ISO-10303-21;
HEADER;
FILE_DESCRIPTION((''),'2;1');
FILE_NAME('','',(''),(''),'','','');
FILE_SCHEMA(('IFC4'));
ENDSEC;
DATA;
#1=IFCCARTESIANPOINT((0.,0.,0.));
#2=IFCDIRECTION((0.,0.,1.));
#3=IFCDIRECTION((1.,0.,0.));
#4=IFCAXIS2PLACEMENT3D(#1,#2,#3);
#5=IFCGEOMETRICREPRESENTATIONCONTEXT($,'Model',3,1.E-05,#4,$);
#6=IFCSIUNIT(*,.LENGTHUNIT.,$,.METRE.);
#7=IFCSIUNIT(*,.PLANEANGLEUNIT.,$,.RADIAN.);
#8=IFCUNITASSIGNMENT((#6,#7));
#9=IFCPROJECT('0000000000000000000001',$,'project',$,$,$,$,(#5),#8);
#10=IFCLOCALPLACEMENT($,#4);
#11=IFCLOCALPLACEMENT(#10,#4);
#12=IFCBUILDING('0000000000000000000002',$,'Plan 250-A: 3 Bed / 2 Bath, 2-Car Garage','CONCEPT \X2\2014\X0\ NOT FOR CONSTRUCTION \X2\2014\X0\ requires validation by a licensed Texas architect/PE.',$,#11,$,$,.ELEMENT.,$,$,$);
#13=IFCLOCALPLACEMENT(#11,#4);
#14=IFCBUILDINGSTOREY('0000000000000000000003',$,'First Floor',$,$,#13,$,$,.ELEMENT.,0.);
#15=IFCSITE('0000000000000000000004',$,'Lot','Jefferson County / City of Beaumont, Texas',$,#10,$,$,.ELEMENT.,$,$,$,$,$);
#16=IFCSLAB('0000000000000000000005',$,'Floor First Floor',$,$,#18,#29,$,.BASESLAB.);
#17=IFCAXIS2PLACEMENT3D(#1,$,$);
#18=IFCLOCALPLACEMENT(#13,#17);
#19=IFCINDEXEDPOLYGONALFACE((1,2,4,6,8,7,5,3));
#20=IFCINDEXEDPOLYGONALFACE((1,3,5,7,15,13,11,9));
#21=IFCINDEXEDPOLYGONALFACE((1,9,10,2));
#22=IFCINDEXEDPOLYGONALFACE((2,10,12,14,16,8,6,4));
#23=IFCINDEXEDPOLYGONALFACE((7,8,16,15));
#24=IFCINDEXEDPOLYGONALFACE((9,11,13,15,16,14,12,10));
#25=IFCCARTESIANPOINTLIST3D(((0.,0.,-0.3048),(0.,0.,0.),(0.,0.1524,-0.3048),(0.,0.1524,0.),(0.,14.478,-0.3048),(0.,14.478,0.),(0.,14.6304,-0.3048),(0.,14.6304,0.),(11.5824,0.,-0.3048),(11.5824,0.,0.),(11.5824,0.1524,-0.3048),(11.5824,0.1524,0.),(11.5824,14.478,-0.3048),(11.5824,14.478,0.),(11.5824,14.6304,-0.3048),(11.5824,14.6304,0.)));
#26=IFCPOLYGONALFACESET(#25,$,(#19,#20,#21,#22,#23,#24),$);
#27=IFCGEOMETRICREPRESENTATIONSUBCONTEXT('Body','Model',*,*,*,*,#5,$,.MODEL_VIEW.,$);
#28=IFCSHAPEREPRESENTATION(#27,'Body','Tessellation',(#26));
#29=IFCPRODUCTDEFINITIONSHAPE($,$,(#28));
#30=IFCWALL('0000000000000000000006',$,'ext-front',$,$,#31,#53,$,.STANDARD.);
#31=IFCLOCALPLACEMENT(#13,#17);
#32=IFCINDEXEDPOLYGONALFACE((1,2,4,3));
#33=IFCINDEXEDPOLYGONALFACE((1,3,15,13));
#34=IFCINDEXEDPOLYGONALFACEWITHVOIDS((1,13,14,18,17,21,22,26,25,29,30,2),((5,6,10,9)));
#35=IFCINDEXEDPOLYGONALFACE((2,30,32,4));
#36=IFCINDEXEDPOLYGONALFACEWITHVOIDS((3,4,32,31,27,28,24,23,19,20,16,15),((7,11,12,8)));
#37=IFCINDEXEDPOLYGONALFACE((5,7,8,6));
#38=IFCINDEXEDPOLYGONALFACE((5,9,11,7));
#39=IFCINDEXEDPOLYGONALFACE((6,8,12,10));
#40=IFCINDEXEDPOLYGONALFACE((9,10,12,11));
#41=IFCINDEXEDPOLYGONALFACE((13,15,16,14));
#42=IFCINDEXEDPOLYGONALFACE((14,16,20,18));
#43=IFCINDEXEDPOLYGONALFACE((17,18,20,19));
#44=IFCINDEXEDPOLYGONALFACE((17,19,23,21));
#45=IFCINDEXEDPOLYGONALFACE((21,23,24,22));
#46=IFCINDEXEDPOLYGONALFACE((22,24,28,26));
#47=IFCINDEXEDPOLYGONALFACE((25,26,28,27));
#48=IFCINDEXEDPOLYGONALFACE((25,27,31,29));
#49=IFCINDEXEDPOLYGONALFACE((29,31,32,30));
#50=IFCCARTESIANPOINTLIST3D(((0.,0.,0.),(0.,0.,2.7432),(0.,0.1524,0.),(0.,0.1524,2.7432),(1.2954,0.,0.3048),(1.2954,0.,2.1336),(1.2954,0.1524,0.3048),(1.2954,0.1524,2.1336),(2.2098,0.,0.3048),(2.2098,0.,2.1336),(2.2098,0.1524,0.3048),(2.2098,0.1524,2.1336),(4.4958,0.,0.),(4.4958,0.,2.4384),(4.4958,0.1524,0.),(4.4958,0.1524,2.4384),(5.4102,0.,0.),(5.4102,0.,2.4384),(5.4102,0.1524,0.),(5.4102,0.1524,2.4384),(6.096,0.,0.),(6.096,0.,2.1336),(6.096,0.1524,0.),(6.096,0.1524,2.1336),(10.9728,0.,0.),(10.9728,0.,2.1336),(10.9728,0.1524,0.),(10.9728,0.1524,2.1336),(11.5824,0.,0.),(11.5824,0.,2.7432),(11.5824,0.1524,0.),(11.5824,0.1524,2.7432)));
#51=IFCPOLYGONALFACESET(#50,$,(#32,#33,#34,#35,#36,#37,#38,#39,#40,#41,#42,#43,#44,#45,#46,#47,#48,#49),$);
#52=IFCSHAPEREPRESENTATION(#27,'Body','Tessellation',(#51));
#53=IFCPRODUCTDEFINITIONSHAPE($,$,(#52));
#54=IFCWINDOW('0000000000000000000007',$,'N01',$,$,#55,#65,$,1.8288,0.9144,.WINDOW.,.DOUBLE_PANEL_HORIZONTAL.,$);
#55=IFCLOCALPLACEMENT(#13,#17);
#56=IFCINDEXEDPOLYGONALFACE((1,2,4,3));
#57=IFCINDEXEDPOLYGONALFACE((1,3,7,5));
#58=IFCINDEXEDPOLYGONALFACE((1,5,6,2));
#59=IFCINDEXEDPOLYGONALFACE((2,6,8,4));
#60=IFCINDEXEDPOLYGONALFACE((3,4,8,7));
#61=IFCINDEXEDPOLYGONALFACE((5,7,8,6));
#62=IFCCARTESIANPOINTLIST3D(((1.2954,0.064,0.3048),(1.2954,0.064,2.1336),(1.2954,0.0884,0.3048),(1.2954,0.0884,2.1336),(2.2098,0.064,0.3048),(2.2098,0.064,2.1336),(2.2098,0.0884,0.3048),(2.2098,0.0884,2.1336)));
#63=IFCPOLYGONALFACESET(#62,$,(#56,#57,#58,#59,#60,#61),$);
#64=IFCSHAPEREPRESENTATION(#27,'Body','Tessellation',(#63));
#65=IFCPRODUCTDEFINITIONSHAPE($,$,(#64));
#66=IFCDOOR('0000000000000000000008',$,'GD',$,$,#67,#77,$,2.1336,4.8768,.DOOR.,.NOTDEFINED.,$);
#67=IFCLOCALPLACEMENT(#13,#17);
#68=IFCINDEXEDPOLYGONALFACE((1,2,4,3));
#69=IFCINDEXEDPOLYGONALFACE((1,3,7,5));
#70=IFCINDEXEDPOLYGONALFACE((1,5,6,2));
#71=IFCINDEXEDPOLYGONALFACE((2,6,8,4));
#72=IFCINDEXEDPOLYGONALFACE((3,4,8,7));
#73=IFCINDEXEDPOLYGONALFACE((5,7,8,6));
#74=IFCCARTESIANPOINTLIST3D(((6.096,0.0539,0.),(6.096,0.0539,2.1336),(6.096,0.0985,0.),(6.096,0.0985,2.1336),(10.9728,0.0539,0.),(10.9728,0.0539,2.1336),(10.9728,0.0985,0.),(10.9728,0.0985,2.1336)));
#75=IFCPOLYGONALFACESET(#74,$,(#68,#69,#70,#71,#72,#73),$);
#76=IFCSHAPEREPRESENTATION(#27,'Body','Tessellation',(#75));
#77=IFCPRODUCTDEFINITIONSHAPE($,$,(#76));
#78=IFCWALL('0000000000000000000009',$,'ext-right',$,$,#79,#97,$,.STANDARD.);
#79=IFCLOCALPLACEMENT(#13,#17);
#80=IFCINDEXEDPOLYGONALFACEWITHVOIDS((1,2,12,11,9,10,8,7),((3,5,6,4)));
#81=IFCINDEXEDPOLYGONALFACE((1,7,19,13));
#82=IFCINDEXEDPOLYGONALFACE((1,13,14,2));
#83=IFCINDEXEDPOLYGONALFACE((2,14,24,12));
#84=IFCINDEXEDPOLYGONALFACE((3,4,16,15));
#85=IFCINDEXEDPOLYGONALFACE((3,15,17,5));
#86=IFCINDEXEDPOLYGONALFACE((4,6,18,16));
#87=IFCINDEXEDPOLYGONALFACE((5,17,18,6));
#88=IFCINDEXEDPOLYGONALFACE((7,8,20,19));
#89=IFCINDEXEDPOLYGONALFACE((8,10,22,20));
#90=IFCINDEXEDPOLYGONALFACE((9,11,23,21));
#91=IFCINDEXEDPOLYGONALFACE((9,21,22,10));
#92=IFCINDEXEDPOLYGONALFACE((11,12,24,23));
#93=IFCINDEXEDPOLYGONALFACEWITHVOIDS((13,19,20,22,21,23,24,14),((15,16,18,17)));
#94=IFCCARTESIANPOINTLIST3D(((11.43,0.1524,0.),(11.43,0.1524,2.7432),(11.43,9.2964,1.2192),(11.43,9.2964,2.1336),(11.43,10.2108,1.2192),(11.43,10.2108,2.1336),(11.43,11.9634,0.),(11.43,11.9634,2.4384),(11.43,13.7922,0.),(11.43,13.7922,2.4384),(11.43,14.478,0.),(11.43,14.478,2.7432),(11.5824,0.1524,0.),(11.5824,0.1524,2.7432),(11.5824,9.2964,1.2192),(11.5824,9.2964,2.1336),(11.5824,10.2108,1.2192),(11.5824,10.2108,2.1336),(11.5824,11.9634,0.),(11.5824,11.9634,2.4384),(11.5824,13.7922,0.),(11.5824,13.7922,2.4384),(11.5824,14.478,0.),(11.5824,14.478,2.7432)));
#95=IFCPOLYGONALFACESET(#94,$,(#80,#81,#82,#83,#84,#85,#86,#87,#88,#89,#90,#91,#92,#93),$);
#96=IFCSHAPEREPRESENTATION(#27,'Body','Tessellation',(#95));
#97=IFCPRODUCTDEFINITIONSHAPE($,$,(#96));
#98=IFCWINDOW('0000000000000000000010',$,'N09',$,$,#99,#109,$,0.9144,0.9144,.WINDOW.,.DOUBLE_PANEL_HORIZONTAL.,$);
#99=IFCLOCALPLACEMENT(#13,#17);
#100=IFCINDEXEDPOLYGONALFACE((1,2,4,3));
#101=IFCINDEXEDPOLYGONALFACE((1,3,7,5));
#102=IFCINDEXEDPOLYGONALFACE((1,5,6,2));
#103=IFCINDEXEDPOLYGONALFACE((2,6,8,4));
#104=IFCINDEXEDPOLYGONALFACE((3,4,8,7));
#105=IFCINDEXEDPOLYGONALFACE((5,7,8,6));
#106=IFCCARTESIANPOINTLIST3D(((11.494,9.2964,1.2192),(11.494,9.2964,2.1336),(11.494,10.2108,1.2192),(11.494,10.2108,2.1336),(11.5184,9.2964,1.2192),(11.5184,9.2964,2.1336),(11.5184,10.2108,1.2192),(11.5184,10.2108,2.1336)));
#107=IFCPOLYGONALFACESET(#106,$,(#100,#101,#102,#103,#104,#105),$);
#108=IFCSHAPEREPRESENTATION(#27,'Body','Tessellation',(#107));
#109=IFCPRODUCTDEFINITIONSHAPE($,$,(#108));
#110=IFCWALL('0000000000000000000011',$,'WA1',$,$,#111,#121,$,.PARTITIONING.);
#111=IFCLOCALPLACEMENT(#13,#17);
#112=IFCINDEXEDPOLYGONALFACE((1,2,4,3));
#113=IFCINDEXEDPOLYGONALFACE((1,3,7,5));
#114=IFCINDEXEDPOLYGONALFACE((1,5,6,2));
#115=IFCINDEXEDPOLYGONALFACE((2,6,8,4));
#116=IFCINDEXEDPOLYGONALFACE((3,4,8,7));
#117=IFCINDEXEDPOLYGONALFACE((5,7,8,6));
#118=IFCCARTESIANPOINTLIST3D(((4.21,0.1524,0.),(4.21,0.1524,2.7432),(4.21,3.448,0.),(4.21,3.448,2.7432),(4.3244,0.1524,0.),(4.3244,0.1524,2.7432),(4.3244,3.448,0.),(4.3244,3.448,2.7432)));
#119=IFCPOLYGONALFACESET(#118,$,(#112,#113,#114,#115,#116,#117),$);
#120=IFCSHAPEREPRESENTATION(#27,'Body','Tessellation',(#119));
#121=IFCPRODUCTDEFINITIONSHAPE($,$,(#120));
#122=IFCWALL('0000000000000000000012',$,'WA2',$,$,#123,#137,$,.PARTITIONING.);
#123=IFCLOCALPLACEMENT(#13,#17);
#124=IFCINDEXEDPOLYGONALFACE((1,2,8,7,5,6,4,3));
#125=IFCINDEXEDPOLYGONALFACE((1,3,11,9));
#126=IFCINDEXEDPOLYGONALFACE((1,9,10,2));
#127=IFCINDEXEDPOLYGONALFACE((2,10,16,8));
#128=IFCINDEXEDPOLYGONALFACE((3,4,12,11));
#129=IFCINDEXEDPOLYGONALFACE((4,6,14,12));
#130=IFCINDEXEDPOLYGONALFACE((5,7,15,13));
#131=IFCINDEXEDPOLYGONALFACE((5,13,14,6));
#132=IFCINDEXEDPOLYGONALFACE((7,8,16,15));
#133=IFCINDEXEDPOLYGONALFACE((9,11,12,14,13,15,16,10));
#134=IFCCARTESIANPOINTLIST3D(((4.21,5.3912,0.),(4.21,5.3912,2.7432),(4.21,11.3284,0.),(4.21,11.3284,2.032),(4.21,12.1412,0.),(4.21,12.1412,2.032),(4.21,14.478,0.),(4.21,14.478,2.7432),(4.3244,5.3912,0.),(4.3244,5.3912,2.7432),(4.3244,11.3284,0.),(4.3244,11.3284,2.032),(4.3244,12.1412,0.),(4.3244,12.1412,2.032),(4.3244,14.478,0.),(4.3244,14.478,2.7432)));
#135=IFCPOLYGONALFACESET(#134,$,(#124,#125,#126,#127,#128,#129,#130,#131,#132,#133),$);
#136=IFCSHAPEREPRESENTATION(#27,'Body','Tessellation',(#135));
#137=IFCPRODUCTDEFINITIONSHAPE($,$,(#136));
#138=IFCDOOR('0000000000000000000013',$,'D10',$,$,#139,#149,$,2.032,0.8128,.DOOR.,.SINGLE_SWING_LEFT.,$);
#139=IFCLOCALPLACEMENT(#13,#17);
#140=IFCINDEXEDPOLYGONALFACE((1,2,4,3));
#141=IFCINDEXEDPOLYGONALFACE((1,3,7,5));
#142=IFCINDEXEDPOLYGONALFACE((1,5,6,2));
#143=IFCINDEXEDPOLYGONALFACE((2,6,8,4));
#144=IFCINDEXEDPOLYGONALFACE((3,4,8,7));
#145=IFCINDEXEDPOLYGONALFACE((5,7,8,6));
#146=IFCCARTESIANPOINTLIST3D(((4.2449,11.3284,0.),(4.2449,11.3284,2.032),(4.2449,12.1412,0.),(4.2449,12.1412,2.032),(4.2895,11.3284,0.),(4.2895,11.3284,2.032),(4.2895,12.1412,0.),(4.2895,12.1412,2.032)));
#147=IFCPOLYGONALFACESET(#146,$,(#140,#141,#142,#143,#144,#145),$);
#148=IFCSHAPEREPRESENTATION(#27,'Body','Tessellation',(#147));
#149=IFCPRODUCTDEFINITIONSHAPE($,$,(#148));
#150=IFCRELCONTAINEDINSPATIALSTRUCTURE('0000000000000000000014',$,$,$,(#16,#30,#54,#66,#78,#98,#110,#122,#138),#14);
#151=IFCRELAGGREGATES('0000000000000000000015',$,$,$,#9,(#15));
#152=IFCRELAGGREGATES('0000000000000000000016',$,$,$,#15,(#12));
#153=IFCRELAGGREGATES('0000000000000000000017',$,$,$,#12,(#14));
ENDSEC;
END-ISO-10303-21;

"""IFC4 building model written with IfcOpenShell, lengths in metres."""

from ifc_helpers import new_model, si_unit, frame, frame_2d, origin_with_axes, place, context, subcontext, project, spatial, polyline, rectangle, outline, extrude, element, fill, save


model = new_model("IFC4")

# Units and contexts
model_context = context("Model", 3, precision=1e-05, world=origin_with_axes())
body_context = subcontext(model_context, "Body", "Model", "MODEL_VIEW")
ifc_project = project(units=[si_unit("LENGTHUNIT", "METRE"), si_unit("PLANEANGLEUNIT", "RADIAN")], contexts=[model_context])

# Site, building, storey
site_placement = place(None, origin_with_axes())
site = spatial("IfcSite", under=ifc_project, at=site_placement, Name="Lot", Description="Jefferson County / City of Beaumont, Texas", CompositionType="ELEMENT")
building_placement = place(site_placement, origin_with_axes())
building = spatial("IfcBuilding", under=site, at=building_placement, Name="Plan 250-A: 3 Bed / 2 Bath, 2-Car Garage", Description="CONCEPT — NOT FOR CONSTRUCTION — requires validation by a licensed Texas architect/PE.", CompositionType="ELEMENT")
storey_placement = place(building_placement, origin_with_axes())
storey = spatial("IfcBuildingStorey", under=building, at=storey_placement, Name="First Floor", CompositionType="ELEMENT", Elevation=0.0)

# Slab
slab_placement = place(storey_placement, frame((0.0, 0.0, -0.3048), z_axis=(0.0, 0.0, 1.0), x_axis=(1.0, 0.0, 0.0)))
element("IfcSlab", 1, at=slab_placement, inside=storey, Name="Floor First Floor", PredefinedType="BASESLAB", context=body_context, shape_type="SweptSolid", body=[
    extrude(outline(polyline([(11.5824, 0.1524), (11.5824, 0.0), (0.0, 0.0), (0.0, 0.1524), (0.0, 14.478), (0.0, 14.6304), (11.5824, 14.6304), (11.5824, 14.478), (11.5824, 0.1524)])), origin_with_axes(), (0.0, 0.0, 1.0), 0.3048),
])

# Wall, openings, window, door
wall_1_placement = place(storey_placement, frame((0.0, 0.0762, 0.0), z_axis=(0.0, 0.0, 1.0), x_axis=(1.0, 0.0, 0.0)))
wall_1 = element("IfcWall", 2, at=wall_1_placement, inside=storey, Name="ext-front", PredefinedType="STANDARD", context=body_context, shape_type="SweptSolid", body=[
    extrude(rectangle(XDim=11.5824, YDim=0.1524, at=frame_2d((5.7912, 0.0), x_axis=(1.0, 0.0))), origin_with_axes(), (0.0, 0.0, 1.0), 2.7432),
])
opening_1_placement = place(wall_1_placement, frame((1.2954, 0.0, 0.3048), z_axis=(0.0, 0.0, 1.0), x_axis=(1.0, 0.0, 0.0)))
opening_1 = element("IfcOpeningElement", 3, at=opening_1_placement, cuts=wall_1, PredefinedType="OPENING", context=body_context, shape_type="SweptSolid", body=[
    extrude(rectangle(XDim=0.9144, YDim=0.1829, at=frame_2d((0.4572, 0.0), x_axis=(1.0, 0.0))), origin_with_axes(), (0.0, 0.0, 1.0), 1.8288),
])
opening_2_placement = place(wall_1_placement, frame((4.4958, 0.0, 0.0), z_axis=(0.0, 0.0, 1.0), x_axis=(1.0, 0.0, 0.0)))
element("IfcOpeningElement", 4, at=opening_2_placement, cuts=wall_1, PredefinedType="OPENING", context=body_context, shape_type="SweptSolid", body=[
    extrude(rectangle(XDim=0.9144, YDim=0.1829, at=frame_2d((0.4572, 0.0), x_axis=(1.0, 0.0))), origin_with_axes(), (0.0, 0.0, 1.0), 2.4384),
])
opening_3_placement = place(wall_1_placement, frame((6.096, 0.0, 0.0), z_axis=(0.0, 0.0, 1.0), x_axis=(1.0, 0.0, 0.0)))
opening_3 = element("IfcOpeningElement", 5, at=opening_3_placement, cuts=wall_1, PredefinedType="OPENING", context=body_context, shape_type="SweptSolid", body=[
    extrude(rectangle(XDim=4.8768, YDim=0.1829, at=frame_2d((2.4384, 0.0), x_axis=(1.0, 0.0))), origin_with_axes(), (0.0, 0.0, 1.0), 2.1336),
])
window_1_placement = place(opening_1_placement, origin_with_axes())
window_1 = element("IfcWindow", 6, at=window_1_placement, inside=storey, Name="N01", OverallHeight=1.8288, OverallWidth=0.9144, PartitioningType="DOUBLE_PANEL_HORIZONTAL", PredefinedType="WINDOW", context=body_context, shape_type="SweptSolid", body=[
    extrude(rectangle(XDim=0.9144, YDim=0.0244, at=frame_2d((0.4572, 0.0), x_axis=(1.0, 0.0))), origin_with_axes(), (0.0, 0.0, 1.0), 1.8288),
])
fill(opening_1, window_1)
door_1_placement = place(opening_3_placement, origin_with_axes())
door_1 = element("IfcDoor", 7, at=door_1_placement, inside=storey, Name="GD", OperationType="NOTDEFINED", OverallHeight=2.1336, OverallWidth=4.8768, PredefinedType="DOOR", context=body_context, shape_type="SweptSolid", body=[
    extrude(rectangle(XDim=4.8768, YDim=0.0445, at=frame_2d((2.4384, 0.0), x_axis=(1.0, 0.0))), origin_with_axes(), (0.0, 0.0, 1.0), 2.1336),
])
fill(opening_3, door_1)

# Wall, openings, window
wall_2_placement = place(storey_placement, frame((11.5062, 0.1524, 0.0), z_axis=(0.0, 0.0, 1.0), x_axis=(0.0, 1.0, 0.0)))
wall_2 = element("IfcWall", 8, at=wall_2_placement, inside=storey, Name="ext-right", PredefinedType="STANDARD", context=body_context, shape_type="SweptSolid", body=[
    extrude(rectangle(XDim=14.3256, YDim=0.1524, at=frame_2d((7.1628, 0.0), x_axis=(1.0, 0.0))), origin_with_axes(), (0.0, 0.0, 1.0), 2.7432),
])
opening_4_placement = place(wall_2_placement, frame((9.144, 0.0, 1.2192), z_axis=(0.0, 0.0, 1.0), x_axis=(1.0, 0.0, 0.0)))
opening_4 = element("IfcOpeningElement", 9, at=opening_4_placement, cuts=wall_2, PredefinedType="OPENING", context=body_context, shape_type="SweptSolid", body=[
    extrude(rectangle(XDim=0.9144, YDim=0.1829, at=frame_2d((0.4572, 0.0), x_axis=(1.0, 0.0))), origin_with_axes(), (0.0, 0.0, 1.0), 0.9144),
])
opening_5_placement = place(wall_2_placement, frame((11.811, 0.0, 0.0), z_axis=(0.0, 0.0, 1.0), x_axis=(1.0, 0.0, 0.0)))
element("IfcOpeningElement", 10, at=opening_5_placement, cuts=wall_2, PredefinedType="OPENING", context=body_context, shape_type="SweptSolid", body=[
    extrude(rectangle(XDim=1.8288, YDim=0.1829, at=frame_2d((0.9144, 0.0), x_axis=(1.0, 0.0))), origin_with_axes(), (0.0, 0.0, 1.0), 2.4384),
])
window_2_placement = place(opening_4_placement, origin_with_axes())
window_2 = element("IfcWindow", 11, at=window_2_placement, inside=storey, Name="N09", OverallHeight=0.9144, OverallWidth=0.9144, PartitioningType="DOUBLE_PANEL_HORIZONTAL", PredefinedType="WINDOW", context=body_context, shape_type="SweptSolid", body=[
    extrude(rectangle(XDim=0.9144, YDim=0.0244, at=frame_2d((0.4572, 0.0), x_axis=(1.0, 0.0))), origin_with_axes(), (0.0, 0.0, 1.0), 0.9144),
])
fill(opening_4, window_2)

# Wall
wall_3_placement = place(storey_placement, frame((4.2672, 0.1524, 0.0), z_axis=(0.0, 0.0, 1.0), x_axis=(0.0, 1.0, 0.0)))
element("IfcWall", 12, at=wall_3_placement, inside=storey, Name="WA1", PredefinedType="PARTITIONING", context=body_context, shape_type="SweptSolid", body=[
    extrude(rectangle(XDim=3.2957, YDim=0.1143, at=frame_2d((1.6478, 0.0), x_axis=(1.0, 0.0))), origin_with_axes(), (0.0, 0.0, 1.0), 2.7432),
])

# Wall, opening, door
wall_4_placement = place(storey_placement, frame((4.2672, 5.3912, 0.0), z_axis=(0.0, 0.0, 1.0), x_axis=(0.0, 1.0, 0.0)))
wall_4 = element("IfcWall", 13, at=wall_4_placement, inside=storey, Name="WA2", PredefinedType="PARTITIONING", context=body_context, shape_type="SweptSolid", body=[
    extrude(rectangle(XDim=9.0869, YDim=0.1143, at=frame_2d((4.5434, 0.0), x_axis=(1.0, 0.0))), origin_with_axes(), (0.0, 0.0, 1.0), 2.7432),
])
opening_6_placement = place(wall_4_placement, frame((5.9372, 0.0, 0.0), z_axis=(0.0, 0.0, 1.0), x_axis=(1.0, 0.0, 0.0)))
opening_6 = element("IfcOpeningElement", 14, at=opening_6_placement, cuts=wall_4, PredefinedType="OPENING", context=body_context, shape_type="SweptSolid", body=[
    extrude(rectangle(XDim=0.8128, YDim=0.1448, at=frame_2d((0.4064, 0.0), x_axis=(1.0, 0.0))), origin_with_axes(), (0.0, 0.0, 1.0), 2.032),
])
door_2_placement = place(opening_6_placement, origin_with_axes())
door_2 = element("IfcDoor", 15, at=door_2_placement, inside=storey, Name="D10", OperationType="SINGLE_SWING_LEFT", OverallHeight=2.032, OverallWidth=0.8128, PredefinedType="DOOR", context=body_context, shape_type="SweptSolid", body=[
    extrude(rectangle(XDim=0.8128, YDim=0.0445, at=frame_2d((0.4064, 0.0), x_axis=(1.0, 0.0))), origin_with_axes(), (0.0, 0.0, 1.0), 2.032),
])
fill(opening_6, door_2)

save(model, "model.ifc")
